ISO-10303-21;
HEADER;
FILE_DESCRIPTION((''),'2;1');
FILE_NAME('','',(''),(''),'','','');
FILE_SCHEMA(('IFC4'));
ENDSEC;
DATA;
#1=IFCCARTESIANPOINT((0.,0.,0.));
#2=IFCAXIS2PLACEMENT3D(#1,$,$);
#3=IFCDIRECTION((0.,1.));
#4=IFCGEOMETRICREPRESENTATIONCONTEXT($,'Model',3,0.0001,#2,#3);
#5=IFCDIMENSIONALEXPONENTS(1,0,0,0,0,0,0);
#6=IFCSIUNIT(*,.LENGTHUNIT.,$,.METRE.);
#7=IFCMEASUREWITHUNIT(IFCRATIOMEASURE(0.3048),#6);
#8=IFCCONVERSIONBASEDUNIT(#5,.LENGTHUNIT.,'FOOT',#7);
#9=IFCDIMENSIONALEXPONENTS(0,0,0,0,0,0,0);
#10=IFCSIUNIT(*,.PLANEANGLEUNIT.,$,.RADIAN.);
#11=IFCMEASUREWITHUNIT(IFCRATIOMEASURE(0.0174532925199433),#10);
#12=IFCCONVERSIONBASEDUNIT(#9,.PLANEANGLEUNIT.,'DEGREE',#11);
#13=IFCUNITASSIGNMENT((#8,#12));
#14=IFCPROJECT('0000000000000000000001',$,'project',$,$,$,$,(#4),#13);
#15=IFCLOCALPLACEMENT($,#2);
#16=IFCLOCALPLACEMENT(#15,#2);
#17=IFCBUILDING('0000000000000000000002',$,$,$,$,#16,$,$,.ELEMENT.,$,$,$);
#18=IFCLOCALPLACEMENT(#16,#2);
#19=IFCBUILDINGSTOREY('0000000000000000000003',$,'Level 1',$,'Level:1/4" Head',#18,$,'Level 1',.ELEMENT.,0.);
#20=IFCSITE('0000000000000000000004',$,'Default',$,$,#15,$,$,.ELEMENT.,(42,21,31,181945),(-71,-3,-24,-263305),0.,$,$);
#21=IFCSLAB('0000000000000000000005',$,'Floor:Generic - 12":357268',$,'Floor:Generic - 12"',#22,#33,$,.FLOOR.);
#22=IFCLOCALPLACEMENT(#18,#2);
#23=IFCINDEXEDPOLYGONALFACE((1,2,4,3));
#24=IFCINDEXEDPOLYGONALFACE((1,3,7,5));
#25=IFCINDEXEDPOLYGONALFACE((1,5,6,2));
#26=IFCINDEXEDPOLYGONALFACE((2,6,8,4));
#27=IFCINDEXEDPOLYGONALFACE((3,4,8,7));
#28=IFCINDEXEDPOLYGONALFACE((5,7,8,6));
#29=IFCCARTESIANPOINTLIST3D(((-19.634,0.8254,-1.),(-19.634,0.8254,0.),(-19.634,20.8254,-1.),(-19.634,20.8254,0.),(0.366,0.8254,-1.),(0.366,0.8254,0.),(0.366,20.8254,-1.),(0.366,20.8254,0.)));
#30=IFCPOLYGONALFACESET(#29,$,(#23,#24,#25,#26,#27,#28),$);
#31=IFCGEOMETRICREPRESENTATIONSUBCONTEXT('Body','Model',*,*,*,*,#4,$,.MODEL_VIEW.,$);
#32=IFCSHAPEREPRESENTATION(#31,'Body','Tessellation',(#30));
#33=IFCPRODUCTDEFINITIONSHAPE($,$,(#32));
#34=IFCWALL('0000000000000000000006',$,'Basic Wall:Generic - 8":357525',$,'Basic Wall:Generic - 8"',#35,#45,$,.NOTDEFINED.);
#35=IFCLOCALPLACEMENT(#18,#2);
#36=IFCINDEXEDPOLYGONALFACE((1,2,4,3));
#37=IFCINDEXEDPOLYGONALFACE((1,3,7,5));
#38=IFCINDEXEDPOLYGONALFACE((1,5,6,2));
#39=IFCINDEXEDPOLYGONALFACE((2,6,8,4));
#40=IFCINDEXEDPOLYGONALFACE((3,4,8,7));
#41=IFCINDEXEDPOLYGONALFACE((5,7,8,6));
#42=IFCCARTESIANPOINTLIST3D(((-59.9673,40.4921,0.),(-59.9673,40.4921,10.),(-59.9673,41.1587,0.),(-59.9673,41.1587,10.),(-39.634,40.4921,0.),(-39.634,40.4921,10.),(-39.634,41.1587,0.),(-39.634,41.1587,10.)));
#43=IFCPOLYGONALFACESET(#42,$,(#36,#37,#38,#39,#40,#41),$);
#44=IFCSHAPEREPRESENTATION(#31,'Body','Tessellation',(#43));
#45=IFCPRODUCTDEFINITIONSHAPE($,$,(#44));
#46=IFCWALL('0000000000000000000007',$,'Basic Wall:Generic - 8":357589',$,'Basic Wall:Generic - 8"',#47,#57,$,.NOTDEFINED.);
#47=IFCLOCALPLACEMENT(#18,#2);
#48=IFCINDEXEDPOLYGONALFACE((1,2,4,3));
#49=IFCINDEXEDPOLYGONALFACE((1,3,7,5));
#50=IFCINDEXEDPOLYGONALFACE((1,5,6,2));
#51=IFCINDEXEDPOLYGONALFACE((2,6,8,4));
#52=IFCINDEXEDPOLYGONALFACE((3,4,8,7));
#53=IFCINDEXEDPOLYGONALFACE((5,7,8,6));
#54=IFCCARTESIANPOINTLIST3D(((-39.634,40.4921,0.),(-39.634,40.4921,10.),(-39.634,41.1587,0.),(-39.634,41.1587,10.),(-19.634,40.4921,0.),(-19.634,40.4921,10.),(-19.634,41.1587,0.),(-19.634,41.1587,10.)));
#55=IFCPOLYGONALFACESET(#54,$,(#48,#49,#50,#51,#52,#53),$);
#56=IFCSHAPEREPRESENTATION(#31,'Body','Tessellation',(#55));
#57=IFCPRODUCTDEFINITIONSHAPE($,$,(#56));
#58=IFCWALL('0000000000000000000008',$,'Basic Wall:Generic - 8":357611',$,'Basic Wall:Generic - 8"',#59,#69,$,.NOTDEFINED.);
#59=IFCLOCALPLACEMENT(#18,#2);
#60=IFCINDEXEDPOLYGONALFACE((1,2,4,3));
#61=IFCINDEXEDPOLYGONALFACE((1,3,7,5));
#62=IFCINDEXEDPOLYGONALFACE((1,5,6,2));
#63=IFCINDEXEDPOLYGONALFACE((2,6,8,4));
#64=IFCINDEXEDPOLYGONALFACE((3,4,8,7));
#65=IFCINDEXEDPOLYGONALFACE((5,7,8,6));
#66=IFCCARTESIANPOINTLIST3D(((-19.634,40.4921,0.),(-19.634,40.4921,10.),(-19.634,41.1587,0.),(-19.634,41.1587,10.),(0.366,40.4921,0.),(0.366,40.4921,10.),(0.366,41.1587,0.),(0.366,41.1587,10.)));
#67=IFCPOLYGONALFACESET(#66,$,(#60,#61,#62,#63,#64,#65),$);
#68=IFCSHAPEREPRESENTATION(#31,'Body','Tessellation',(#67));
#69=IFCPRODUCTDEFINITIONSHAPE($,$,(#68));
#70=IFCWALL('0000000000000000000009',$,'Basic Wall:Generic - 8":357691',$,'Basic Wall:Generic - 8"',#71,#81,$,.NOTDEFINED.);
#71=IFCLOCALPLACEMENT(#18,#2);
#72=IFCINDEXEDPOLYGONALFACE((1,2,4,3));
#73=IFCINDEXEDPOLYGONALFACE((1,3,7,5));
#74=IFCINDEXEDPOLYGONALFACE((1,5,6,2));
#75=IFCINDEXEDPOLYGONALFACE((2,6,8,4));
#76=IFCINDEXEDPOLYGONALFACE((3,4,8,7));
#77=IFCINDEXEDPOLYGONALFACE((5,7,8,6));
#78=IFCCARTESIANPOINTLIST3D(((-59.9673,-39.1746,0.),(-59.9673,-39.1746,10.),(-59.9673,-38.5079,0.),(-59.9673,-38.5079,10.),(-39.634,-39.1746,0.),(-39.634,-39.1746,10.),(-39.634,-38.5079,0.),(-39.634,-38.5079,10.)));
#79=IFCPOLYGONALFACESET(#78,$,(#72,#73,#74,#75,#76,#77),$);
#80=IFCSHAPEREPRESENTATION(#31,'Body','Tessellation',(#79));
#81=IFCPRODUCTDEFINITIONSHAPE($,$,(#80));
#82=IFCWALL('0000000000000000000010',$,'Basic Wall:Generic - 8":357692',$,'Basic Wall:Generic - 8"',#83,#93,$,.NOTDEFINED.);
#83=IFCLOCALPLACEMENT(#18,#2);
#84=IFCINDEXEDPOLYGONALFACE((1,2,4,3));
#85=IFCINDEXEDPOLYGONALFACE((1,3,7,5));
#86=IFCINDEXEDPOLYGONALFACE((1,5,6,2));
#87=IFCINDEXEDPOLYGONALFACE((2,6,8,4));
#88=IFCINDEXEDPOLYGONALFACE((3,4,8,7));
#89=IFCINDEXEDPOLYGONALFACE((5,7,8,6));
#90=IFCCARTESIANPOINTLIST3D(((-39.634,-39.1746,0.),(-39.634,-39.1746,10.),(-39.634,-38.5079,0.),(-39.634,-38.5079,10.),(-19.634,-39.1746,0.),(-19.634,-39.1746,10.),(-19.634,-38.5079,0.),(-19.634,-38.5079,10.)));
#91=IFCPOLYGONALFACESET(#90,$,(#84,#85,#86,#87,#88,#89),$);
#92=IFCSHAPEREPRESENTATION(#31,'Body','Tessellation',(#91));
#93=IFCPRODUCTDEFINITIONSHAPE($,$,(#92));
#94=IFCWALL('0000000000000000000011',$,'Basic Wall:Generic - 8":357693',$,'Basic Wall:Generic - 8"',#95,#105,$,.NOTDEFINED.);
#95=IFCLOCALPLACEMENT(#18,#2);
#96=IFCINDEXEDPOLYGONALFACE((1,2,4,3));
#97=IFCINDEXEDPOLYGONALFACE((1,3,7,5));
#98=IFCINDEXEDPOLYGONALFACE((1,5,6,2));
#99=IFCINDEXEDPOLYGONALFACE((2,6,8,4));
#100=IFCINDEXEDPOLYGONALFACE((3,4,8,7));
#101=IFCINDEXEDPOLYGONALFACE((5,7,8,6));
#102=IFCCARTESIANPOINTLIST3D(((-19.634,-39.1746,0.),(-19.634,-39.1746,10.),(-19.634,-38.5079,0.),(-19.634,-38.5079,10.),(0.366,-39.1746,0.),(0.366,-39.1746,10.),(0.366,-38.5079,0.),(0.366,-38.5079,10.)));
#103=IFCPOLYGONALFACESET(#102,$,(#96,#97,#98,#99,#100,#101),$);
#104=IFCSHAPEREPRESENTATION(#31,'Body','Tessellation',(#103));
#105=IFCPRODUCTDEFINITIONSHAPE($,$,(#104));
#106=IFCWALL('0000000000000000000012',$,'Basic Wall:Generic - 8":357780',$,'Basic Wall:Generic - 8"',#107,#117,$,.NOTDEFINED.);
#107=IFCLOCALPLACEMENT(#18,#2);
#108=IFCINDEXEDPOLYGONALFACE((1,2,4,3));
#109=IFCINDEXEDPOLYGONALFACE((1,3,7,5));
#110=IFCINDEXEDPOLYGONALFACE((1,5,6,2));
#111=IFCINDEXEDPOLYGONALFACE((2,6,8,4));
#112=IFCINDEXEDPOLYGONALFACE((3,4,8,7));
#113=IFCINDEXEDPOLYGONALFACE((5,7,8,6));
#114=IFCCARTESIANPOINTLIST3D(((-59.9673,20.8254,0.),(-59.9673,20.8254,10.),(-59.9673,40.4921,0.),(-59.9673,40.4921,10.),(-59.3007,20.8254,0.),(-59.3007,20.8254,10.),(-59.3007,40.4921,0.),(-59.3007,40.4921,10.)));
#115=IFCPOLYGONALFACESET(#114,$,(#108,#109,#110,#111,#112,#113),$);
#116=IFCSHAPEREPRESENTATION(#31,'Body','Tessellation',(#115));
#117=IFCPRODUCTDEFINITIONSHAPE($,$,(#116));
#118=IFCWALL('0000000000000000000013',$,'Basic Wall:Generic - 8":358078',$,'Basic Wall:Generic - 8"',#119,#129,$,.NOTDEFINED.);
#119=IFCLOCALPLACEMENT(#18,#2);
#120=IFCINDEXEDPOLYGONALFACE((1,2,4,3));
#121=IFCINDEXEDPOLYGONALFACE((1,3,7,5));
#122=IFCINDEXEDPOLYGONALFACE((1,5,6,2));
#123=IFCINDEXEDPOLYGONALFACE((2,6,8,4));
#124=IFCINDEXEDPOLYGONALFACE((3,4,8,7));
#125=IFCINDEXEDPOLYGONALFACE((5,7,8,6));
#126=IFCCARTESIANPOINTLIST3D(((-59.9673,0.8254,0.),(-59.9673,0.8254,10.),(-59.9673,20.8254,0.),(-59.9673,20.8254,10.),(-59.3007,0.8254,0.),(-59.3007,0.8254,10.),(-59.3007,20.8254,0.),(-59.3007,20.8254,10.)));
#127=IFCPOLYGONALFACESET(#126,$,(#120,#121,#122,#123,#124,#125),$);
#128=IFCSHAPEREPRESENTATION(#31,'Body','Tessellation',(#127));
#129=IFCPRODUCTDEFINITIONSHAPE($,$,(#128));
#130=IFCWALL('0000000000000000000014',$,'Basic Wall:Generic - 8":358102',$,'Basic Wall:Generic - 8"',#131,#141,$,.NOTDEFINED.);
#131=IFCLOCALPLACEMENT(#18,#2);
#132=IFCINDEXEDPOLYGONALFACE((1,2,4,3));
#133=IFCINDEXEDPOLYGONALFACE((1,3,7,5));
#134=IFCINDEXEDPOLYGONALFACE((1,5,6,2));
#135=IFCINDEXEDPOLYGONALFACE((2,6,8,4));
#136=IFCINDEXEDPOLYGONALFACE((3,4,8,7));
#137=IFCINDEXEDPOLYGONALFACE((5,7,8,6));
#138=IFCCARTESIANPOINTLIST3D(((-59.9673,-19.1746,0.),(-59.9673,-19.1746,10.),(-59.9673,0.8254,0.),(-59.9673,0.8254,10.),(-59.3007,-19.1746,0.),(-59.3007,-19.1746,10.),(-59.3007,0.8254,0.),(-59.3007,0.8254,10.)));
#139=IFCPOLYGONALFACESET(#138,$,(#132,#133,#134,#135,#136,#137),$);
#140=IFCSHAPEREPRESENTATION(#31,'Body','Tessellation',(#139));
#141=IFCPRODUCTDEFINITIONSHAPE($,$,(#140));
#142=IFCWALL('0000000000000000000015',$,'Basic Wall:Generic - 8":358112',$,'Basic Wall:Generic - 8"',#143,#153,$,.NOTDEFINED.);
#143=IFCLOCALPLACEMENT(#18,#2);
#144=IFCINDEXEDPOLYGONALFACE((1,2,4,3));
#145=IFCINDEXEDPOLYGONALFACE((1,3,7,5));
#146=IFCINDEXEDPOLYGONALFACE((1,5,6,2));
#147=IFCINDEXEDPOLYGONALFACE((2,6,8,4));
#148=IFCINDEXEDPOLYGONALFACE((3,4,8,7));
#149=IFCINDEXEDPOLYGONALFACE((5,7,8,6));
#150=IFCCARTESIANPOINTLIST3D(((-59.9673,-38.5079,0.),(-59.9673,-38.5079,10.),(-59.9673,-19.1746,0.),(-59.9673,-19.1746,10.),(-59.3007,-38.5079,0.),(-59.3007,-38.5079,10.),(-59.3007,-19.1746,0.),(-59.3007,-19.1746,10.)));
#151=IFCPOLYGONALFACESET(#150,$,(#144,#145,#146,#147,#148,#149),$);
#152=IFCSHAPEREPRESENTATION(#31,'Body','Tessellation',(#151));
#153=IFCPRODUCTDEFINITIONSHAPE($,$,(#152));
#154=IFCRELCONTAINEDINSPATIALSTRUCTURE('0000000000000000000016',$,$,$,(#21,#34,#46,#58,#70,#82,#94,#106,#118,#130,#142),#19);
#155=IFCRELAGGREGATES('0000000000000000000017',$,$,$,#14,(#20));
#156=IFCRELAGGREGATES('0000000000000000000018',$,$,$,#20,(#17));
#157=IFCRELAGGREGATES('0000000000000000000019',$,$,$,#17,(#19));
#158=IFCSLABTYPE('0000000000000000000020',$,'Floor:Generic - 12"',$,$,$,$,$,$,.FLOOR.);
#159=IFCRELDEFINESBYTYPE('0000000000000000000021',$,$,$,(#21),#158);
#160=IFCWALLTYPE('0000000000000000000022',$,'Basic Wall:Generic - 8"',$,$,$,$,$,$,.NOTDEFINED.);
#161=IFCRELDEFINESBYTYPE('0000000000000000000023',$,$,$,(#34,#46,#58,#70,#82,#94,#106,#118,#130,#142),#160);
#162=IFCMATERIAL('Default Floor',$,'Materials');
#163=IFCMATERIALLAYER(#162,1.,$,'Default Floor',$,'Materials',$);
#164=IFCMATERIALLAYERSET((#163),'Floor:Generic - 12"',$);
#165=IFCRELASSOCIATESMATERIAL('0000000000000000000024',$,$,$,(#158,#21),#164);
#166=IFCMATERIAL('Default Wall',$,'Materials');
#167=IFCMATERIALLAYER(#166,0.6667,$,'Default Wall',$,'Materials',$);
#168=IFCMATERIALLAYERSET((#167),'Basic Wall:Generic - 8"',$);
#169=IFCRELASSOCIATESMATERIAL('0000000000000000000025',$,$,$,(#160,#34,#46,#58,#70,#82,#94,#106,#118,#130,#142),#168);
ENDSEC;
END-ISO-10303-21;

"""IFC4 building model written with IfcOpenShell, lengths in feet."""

from ifc_helpers import new_model, entity, si_unit, converted_unit, direction, frame, frame_2d, origin, origin_2d_with_axis, place, context, subcontext, project, spatial, rectangle, extrude, material, layer, layer_set, layer_usage, type_object, element, save


model = new_model("IFC4")

# Units and contexts
model_context = context("Model", 3, precision=0.0001, world=origin(), true_north=direction((0.0, 1.0)))
body_context = subcontext(model_context, "Body", "Model", "MODEL_VIEW")
ifc_project = project(units=[converted_unit("LENGTHUNIT", "FOOT", entity("IfcRatioMeasure", 0.3048), si_unit("LENGTHUNIT", "METRE"), dimensions=[1, 0, 0, 0, 0, 0, 0]), converted_unit("PLANEANGLEUNIT", "DEGREE", entity("IfcRatioMeasure", 0.0174532925199433), si_unit("PLANEANGLEUNIT", "RADIAN"), dimensions=[0, 0, 0, 0, 0, 0, 0])], contexts=[model_context])

# Site, building, storey
site_placement = place(None, origin())
site = spatial("IfcSite", under=ifc_project, at=site_placement, Name="Default", CompositionType="ELEMENT", RefLatitude=(42, 21, 31, 181945), RefLongitude=(-71, -3, -24, -263305), RefElevation=0.0)
building_placement = place(site_placement, origin())
building = spatial("IfcBuilding", under=site, at=building_placement, CompositionType="ELEMENT")
storey_placement = place(building_placement, origin())
storey = spatial("IfcBuildingStorey", under=building, at=storey_placement, Name="Level 1", ObjectType="Level:1/4\" Head", LongName="Level 1", CompositionType="ELEMENT", Elevation=0.0)

# Slab
ifc_material_1 = material(Name="Default Floor", Category="Materials")
ifc_layer_1 = layer(ifc_material_1, 1.0, Name="Default Floor", Category="Materials")
ifc_layer_set_1 = layer_set([ifc_layer_1], Name="Floor:Generic - 12\"")
ifc_layer_usage_1 = layer_usage(ifc_layer_set_1, "AXIS3", "POSITIVE", 0.0)
slab_type_1 = type_object("IfcSlabType", Name="Floor:Generic - 12\"", PredefinedType="FLOOR", material=ifc_layer_set_1)
slab_1_placement = place(storey_placement, origin())
element("IfcSlab", 1, at=slab_1_placement, inside=storey, type_object=slab_type_1, material=ifc_layer_usage_1, Name="Floor:Generic - 12\":357268", ObjectType="Floor:Generic - 12\"", PredefinedType="FLOOR", context=body_context, shape_type="SweptSolid", body=[
    extrude(rectangle(XDim=20.0, YDim=20.0, at=origin_2d_with_axis()), frame((-9.634, 10.8254, 0.0), z_axis=(0.0, 0.0, -1.0), x_axis=(0.0, 1.0, 0.0)), (0.0, 0.0, 1.0), 1.0),
])

# Walls
ifc_material_2 = material(Name="Default Wall", Category="Materials")
ifc_layer_2 = layer(ifc_material_2, 0.6667, Name="Default Wall", Category="Materials")
ifc_layer_set_2 = layer_set([ifc_layer_2], Name="Basic Wall:Generic - 8\"")
ifc_layer_usage_2 = layer_usage(ifc_layer_set_2, "AXIS2", "NEGATIVE", 0.3333)
wall_type = type_object("IfcWallType", Name="Basic Wall:Generic - 8\"", PredefinedType="NOTDEFINED", material=ifc_layer_set_2)
wall_1_placement = place(storey_placement, frame((-59.9673, 40.8254, 0.0)))
element("IfcWall", 2, at=wall_1_placement, inside=storey, type_object=wall_type, material=ifc_layer_usage_2, Name="Basic Wall:Generic - 8\":357525", ObjectType="Basic Wall:Generic - 8\"", PredefinedType="NOTDEFINED", context=body_context, shape_type="SweptSolid", body=[
    extrude(rectangle(XDim=20.3333, YDim=0.6667, at=frame_2d((10.1667, 0.0), x_axis=(-1.0, 0.0))), origin(), (0.0, 0.0, 1.0), 10.0),
])
ifc_layer_usage_3 = layer_usage(ifc_layer_set_2, "AXIS2", "NEGATIVE", 0.3333)
wall_2_placement = place(storey_placement, frame((-39.634, 40.8254, 0.0)))
element("IfcWall", 3, at=wall_2_placement, inside=storey, type_object=wall_type, material=ifc_layer_usage_3, Name="Basic Wall:Generic - 8\":357589", ObjectType="Basic Wall:Generic - 8\"", PredefinedType="NOTDEFINED", context=body_context, shape_type="SweptSolid", body=[
    extrude(rectangle(XDim=20.0, YDim=0.6667, at=frame_2d((10.0, 0.0), x_axis=(-1.0, 0.0))), origin(), (0.0, 0.0, 1.0), 10.0),
])
ifc_layer_usage_4 = layer_usage(ifc_layer_set_2, "AXIS2", "NEGATIVE", 0.3333)
wall_3_placement = place(storey_placement, frame((-19.634, 40.8254, 0.0)))
element("IfcWall", 4, at=wall_3_placement, inside=storey, type_object=wall_type, material=ifc_layer_usage_4, Name="Basic Wall:Generic - 8\":357611", ObjectType="Basic Wall:Generic - 8\"", PredefinedType="NOTDEFINED", context=body_context, shape_type="SweptSolid", body=[
    extrude(rectangle(XDim=20.0, YDim=0.6667, at=frame_2d((10.0, 0.0), x_axis=(-1.0, 0.0))), origin(), (0.0, 0.0, 1.0), 10.0),
])
ifc_layer_usage_5 = layer_usage(ifc_layer_set_2, "AXIS2", "NEGATIVE", 0.3333)
wall_4_placement = place(storey_placement, frame((-59.9673, -38.8413, 0.0)))
element("IfcWall", 5, at=wall_4_placement, inside=storey, type_object=wall_type, material=ifc_layer_usage_5, Name="Basic Wall:Generic - 8\":357691", ObjectType="Basic Wall:Generic - 8\"", PredefinedType="NOTDEFINED", context=body_context, shape_type="SweptSolid", body=[
    extrude(rectangle(XDim=20.3333, YDim=0.6667, at=frame_2d((10.1667, 0.0), x_axis=(-1.0, 0.0))), origin(), (0.0, 0.0, 1.0), 10.0),
])
ifc_layer_usage_6 = layer_usage(ifc_layer_set_2, "AXIS2", "NEGATIVE", 0.3333)
wall_5_placement = place(storey_placement, frame((-39.634, -38.8413, 0.0)))
element("IfcWall", 6, at=wall_5_placement, inside=storey, type_object=wall_type, material=ifc_layer_usage_6, Name="Basic Wall:Generic - 8\":357692", ObjectType="Basic Wall:Generic - 8\"", PredefinedType="NOTDEFINED", context=body_context, shape_type="SweptSolid", body=[
    extrude(rectangle(XDim=20.0, YDim=0.6667, at=frame_2d((10.0, 0.0), x_axis=(-1.0, 0.0))), origin(), (0.0, 0.0, 1.0), 10.0),
])
ifc_layer_usage_7 = layer_usage(ifc_layer_set_2, "AXIS2", "NEGATIVE", 0.3333)
wall_6_placement = place(storey_placement, frame((-19.634, -38.8413, 0.0)))
element("IfcWall", 7, at=wall_6_placement, inside=storey, type_object=wall_type, material=ifc_layer_usage_7, Name="Basic Wall:Generic - 8\":357693", ObjectType="Basic Wall:Generic - 8\"", PredefinedType="NOTDEFINED", context=body_context, shape_type="SweptSolid", body=[
    extrude(rectangle(XDim=20.0, YDim=0.6667, at=frame_2d((10.0, 0.0), x_axis=(-1.0, 0.0))), origin(), (0.0, 0.0, 1.0), 10.0),
])
ifc_layer_usage_8 = layer_usage(ifc_layer_set_2, "AXIS2", "NEGATIVE", 0.3333)
wall_7_placement = place(storey_placement, frame((-59.634, 40.4921, 0.0), z_axis=(0.0, 0.0, 1.0), x_axis=(0.0, -1.0, 0.0)))
element("IfcWall", 8, at=wall_7_placement, inside=storey, type_object=wall_type, material=ifc_layer_usage_8, Name="Basic Wall:Generic - 8\":357780", ObjectType="Basic Wall:Generic - 8\"", PredefinedType="NOTDEFINED", context=body_context, shape_type="SweptSolid", body=[
    extrude(rectangle(XDim=19.6667, YDim=0.6667, at=frame_2d((9.8333, 0.0), x_axis=(-1.0, 0.0))), origin(), (0.0, 0.0, 1.0), 10.0),
])
ifc_layer_usage_9 = layer_usage(ifc_layer_set_2, "AXIS2", "NEGATIVE", 0.3333)
wall_8_placement = place(storey_placement, frame((-59.634, 20.8254, 0.0), z_axis=(0.0, 0.0, 1.0), x_axis=(0.0, -1.0, 0.0)))
element("IfcWall", 9, at=wall_8_placement, inside=storey, type_object=wall_type, material=ifc_layer_usage_9, Name="Basic Wall:Generic - 8\":358078", ObjectType="Basic Wall:Generic - 8\"", PredefinedType="NOTDEFINED", context=body_context, shape_type="SweptSolid", body=[
    extrude(rectangle(XDim=20.0, YDim=0.6667, at=frame_2d((10.0, 0.0), x_axis=(-1.0, 0.0))), origin(), (0.0, 0.0, 1.0), 10.0),
])
ifc_layer_usage_10 = layer_usage(ifc_layer_set_2, "AXIS2", "NEGATIVE", 0.3333)
wall_9_placement = place(storey_placement, frame((-59.634, 0.8254, 0.0), z_axis=(0.0, 0.0, 1.0), x_axis=(0.0, -1.0, 0.0)))
element("IfcWall", 10, at=wall_9_placement, inside=storey, type_object=wall_type, material=ifc_layer_usage_10, Name="Basic Wall:Generic - 8\":358102", ObjectType="Basic Wall:Generic - 8\"", PredefinedType="NOTDEFINED", context=body_context, shape_type="SweptSolid", body=[
    extrude(rectangle(XDim=20.0, YDim=0.6667, at=frame_2d((10.0, 0.0), x_axis=(-1.0, 0.0))), origin(), (0.0, 0.0, 1.0), 10.0),
])
ifc_layer_usage_11 = layer_usage(ifc_layer_set_2, "AXIS2", "NEGATIVE", 0.3333)
wall_10_placement = place(storey_placement, frame((-59.634, -19.1746, 0.0), z_axis=(0.0, 0.0, 1.0), x_axis=(0.0, -1.0, 0.0)))
element("IfcWall", 11, at=wall_10_placement, inside=storey, type_object=wall_type, material=ifc_layer_usage_11, Name="Basic Wall:Generic - 8\":358112", ObjectType="Basic Wall:Generic - 8\"", PredefinedType="NOTDEFINED", context=body_context, shape_type="SweptSolid", body=[
    extrude(rectangle(XDim=19.3333, YDim=0.6667, at=frame_2d((9.6667, 0.0), x_axis=(-1.0, 0.0))), origin(), (0.0, 0.0, 1.0), 10.0),
])

save(model, "model.ifc")
